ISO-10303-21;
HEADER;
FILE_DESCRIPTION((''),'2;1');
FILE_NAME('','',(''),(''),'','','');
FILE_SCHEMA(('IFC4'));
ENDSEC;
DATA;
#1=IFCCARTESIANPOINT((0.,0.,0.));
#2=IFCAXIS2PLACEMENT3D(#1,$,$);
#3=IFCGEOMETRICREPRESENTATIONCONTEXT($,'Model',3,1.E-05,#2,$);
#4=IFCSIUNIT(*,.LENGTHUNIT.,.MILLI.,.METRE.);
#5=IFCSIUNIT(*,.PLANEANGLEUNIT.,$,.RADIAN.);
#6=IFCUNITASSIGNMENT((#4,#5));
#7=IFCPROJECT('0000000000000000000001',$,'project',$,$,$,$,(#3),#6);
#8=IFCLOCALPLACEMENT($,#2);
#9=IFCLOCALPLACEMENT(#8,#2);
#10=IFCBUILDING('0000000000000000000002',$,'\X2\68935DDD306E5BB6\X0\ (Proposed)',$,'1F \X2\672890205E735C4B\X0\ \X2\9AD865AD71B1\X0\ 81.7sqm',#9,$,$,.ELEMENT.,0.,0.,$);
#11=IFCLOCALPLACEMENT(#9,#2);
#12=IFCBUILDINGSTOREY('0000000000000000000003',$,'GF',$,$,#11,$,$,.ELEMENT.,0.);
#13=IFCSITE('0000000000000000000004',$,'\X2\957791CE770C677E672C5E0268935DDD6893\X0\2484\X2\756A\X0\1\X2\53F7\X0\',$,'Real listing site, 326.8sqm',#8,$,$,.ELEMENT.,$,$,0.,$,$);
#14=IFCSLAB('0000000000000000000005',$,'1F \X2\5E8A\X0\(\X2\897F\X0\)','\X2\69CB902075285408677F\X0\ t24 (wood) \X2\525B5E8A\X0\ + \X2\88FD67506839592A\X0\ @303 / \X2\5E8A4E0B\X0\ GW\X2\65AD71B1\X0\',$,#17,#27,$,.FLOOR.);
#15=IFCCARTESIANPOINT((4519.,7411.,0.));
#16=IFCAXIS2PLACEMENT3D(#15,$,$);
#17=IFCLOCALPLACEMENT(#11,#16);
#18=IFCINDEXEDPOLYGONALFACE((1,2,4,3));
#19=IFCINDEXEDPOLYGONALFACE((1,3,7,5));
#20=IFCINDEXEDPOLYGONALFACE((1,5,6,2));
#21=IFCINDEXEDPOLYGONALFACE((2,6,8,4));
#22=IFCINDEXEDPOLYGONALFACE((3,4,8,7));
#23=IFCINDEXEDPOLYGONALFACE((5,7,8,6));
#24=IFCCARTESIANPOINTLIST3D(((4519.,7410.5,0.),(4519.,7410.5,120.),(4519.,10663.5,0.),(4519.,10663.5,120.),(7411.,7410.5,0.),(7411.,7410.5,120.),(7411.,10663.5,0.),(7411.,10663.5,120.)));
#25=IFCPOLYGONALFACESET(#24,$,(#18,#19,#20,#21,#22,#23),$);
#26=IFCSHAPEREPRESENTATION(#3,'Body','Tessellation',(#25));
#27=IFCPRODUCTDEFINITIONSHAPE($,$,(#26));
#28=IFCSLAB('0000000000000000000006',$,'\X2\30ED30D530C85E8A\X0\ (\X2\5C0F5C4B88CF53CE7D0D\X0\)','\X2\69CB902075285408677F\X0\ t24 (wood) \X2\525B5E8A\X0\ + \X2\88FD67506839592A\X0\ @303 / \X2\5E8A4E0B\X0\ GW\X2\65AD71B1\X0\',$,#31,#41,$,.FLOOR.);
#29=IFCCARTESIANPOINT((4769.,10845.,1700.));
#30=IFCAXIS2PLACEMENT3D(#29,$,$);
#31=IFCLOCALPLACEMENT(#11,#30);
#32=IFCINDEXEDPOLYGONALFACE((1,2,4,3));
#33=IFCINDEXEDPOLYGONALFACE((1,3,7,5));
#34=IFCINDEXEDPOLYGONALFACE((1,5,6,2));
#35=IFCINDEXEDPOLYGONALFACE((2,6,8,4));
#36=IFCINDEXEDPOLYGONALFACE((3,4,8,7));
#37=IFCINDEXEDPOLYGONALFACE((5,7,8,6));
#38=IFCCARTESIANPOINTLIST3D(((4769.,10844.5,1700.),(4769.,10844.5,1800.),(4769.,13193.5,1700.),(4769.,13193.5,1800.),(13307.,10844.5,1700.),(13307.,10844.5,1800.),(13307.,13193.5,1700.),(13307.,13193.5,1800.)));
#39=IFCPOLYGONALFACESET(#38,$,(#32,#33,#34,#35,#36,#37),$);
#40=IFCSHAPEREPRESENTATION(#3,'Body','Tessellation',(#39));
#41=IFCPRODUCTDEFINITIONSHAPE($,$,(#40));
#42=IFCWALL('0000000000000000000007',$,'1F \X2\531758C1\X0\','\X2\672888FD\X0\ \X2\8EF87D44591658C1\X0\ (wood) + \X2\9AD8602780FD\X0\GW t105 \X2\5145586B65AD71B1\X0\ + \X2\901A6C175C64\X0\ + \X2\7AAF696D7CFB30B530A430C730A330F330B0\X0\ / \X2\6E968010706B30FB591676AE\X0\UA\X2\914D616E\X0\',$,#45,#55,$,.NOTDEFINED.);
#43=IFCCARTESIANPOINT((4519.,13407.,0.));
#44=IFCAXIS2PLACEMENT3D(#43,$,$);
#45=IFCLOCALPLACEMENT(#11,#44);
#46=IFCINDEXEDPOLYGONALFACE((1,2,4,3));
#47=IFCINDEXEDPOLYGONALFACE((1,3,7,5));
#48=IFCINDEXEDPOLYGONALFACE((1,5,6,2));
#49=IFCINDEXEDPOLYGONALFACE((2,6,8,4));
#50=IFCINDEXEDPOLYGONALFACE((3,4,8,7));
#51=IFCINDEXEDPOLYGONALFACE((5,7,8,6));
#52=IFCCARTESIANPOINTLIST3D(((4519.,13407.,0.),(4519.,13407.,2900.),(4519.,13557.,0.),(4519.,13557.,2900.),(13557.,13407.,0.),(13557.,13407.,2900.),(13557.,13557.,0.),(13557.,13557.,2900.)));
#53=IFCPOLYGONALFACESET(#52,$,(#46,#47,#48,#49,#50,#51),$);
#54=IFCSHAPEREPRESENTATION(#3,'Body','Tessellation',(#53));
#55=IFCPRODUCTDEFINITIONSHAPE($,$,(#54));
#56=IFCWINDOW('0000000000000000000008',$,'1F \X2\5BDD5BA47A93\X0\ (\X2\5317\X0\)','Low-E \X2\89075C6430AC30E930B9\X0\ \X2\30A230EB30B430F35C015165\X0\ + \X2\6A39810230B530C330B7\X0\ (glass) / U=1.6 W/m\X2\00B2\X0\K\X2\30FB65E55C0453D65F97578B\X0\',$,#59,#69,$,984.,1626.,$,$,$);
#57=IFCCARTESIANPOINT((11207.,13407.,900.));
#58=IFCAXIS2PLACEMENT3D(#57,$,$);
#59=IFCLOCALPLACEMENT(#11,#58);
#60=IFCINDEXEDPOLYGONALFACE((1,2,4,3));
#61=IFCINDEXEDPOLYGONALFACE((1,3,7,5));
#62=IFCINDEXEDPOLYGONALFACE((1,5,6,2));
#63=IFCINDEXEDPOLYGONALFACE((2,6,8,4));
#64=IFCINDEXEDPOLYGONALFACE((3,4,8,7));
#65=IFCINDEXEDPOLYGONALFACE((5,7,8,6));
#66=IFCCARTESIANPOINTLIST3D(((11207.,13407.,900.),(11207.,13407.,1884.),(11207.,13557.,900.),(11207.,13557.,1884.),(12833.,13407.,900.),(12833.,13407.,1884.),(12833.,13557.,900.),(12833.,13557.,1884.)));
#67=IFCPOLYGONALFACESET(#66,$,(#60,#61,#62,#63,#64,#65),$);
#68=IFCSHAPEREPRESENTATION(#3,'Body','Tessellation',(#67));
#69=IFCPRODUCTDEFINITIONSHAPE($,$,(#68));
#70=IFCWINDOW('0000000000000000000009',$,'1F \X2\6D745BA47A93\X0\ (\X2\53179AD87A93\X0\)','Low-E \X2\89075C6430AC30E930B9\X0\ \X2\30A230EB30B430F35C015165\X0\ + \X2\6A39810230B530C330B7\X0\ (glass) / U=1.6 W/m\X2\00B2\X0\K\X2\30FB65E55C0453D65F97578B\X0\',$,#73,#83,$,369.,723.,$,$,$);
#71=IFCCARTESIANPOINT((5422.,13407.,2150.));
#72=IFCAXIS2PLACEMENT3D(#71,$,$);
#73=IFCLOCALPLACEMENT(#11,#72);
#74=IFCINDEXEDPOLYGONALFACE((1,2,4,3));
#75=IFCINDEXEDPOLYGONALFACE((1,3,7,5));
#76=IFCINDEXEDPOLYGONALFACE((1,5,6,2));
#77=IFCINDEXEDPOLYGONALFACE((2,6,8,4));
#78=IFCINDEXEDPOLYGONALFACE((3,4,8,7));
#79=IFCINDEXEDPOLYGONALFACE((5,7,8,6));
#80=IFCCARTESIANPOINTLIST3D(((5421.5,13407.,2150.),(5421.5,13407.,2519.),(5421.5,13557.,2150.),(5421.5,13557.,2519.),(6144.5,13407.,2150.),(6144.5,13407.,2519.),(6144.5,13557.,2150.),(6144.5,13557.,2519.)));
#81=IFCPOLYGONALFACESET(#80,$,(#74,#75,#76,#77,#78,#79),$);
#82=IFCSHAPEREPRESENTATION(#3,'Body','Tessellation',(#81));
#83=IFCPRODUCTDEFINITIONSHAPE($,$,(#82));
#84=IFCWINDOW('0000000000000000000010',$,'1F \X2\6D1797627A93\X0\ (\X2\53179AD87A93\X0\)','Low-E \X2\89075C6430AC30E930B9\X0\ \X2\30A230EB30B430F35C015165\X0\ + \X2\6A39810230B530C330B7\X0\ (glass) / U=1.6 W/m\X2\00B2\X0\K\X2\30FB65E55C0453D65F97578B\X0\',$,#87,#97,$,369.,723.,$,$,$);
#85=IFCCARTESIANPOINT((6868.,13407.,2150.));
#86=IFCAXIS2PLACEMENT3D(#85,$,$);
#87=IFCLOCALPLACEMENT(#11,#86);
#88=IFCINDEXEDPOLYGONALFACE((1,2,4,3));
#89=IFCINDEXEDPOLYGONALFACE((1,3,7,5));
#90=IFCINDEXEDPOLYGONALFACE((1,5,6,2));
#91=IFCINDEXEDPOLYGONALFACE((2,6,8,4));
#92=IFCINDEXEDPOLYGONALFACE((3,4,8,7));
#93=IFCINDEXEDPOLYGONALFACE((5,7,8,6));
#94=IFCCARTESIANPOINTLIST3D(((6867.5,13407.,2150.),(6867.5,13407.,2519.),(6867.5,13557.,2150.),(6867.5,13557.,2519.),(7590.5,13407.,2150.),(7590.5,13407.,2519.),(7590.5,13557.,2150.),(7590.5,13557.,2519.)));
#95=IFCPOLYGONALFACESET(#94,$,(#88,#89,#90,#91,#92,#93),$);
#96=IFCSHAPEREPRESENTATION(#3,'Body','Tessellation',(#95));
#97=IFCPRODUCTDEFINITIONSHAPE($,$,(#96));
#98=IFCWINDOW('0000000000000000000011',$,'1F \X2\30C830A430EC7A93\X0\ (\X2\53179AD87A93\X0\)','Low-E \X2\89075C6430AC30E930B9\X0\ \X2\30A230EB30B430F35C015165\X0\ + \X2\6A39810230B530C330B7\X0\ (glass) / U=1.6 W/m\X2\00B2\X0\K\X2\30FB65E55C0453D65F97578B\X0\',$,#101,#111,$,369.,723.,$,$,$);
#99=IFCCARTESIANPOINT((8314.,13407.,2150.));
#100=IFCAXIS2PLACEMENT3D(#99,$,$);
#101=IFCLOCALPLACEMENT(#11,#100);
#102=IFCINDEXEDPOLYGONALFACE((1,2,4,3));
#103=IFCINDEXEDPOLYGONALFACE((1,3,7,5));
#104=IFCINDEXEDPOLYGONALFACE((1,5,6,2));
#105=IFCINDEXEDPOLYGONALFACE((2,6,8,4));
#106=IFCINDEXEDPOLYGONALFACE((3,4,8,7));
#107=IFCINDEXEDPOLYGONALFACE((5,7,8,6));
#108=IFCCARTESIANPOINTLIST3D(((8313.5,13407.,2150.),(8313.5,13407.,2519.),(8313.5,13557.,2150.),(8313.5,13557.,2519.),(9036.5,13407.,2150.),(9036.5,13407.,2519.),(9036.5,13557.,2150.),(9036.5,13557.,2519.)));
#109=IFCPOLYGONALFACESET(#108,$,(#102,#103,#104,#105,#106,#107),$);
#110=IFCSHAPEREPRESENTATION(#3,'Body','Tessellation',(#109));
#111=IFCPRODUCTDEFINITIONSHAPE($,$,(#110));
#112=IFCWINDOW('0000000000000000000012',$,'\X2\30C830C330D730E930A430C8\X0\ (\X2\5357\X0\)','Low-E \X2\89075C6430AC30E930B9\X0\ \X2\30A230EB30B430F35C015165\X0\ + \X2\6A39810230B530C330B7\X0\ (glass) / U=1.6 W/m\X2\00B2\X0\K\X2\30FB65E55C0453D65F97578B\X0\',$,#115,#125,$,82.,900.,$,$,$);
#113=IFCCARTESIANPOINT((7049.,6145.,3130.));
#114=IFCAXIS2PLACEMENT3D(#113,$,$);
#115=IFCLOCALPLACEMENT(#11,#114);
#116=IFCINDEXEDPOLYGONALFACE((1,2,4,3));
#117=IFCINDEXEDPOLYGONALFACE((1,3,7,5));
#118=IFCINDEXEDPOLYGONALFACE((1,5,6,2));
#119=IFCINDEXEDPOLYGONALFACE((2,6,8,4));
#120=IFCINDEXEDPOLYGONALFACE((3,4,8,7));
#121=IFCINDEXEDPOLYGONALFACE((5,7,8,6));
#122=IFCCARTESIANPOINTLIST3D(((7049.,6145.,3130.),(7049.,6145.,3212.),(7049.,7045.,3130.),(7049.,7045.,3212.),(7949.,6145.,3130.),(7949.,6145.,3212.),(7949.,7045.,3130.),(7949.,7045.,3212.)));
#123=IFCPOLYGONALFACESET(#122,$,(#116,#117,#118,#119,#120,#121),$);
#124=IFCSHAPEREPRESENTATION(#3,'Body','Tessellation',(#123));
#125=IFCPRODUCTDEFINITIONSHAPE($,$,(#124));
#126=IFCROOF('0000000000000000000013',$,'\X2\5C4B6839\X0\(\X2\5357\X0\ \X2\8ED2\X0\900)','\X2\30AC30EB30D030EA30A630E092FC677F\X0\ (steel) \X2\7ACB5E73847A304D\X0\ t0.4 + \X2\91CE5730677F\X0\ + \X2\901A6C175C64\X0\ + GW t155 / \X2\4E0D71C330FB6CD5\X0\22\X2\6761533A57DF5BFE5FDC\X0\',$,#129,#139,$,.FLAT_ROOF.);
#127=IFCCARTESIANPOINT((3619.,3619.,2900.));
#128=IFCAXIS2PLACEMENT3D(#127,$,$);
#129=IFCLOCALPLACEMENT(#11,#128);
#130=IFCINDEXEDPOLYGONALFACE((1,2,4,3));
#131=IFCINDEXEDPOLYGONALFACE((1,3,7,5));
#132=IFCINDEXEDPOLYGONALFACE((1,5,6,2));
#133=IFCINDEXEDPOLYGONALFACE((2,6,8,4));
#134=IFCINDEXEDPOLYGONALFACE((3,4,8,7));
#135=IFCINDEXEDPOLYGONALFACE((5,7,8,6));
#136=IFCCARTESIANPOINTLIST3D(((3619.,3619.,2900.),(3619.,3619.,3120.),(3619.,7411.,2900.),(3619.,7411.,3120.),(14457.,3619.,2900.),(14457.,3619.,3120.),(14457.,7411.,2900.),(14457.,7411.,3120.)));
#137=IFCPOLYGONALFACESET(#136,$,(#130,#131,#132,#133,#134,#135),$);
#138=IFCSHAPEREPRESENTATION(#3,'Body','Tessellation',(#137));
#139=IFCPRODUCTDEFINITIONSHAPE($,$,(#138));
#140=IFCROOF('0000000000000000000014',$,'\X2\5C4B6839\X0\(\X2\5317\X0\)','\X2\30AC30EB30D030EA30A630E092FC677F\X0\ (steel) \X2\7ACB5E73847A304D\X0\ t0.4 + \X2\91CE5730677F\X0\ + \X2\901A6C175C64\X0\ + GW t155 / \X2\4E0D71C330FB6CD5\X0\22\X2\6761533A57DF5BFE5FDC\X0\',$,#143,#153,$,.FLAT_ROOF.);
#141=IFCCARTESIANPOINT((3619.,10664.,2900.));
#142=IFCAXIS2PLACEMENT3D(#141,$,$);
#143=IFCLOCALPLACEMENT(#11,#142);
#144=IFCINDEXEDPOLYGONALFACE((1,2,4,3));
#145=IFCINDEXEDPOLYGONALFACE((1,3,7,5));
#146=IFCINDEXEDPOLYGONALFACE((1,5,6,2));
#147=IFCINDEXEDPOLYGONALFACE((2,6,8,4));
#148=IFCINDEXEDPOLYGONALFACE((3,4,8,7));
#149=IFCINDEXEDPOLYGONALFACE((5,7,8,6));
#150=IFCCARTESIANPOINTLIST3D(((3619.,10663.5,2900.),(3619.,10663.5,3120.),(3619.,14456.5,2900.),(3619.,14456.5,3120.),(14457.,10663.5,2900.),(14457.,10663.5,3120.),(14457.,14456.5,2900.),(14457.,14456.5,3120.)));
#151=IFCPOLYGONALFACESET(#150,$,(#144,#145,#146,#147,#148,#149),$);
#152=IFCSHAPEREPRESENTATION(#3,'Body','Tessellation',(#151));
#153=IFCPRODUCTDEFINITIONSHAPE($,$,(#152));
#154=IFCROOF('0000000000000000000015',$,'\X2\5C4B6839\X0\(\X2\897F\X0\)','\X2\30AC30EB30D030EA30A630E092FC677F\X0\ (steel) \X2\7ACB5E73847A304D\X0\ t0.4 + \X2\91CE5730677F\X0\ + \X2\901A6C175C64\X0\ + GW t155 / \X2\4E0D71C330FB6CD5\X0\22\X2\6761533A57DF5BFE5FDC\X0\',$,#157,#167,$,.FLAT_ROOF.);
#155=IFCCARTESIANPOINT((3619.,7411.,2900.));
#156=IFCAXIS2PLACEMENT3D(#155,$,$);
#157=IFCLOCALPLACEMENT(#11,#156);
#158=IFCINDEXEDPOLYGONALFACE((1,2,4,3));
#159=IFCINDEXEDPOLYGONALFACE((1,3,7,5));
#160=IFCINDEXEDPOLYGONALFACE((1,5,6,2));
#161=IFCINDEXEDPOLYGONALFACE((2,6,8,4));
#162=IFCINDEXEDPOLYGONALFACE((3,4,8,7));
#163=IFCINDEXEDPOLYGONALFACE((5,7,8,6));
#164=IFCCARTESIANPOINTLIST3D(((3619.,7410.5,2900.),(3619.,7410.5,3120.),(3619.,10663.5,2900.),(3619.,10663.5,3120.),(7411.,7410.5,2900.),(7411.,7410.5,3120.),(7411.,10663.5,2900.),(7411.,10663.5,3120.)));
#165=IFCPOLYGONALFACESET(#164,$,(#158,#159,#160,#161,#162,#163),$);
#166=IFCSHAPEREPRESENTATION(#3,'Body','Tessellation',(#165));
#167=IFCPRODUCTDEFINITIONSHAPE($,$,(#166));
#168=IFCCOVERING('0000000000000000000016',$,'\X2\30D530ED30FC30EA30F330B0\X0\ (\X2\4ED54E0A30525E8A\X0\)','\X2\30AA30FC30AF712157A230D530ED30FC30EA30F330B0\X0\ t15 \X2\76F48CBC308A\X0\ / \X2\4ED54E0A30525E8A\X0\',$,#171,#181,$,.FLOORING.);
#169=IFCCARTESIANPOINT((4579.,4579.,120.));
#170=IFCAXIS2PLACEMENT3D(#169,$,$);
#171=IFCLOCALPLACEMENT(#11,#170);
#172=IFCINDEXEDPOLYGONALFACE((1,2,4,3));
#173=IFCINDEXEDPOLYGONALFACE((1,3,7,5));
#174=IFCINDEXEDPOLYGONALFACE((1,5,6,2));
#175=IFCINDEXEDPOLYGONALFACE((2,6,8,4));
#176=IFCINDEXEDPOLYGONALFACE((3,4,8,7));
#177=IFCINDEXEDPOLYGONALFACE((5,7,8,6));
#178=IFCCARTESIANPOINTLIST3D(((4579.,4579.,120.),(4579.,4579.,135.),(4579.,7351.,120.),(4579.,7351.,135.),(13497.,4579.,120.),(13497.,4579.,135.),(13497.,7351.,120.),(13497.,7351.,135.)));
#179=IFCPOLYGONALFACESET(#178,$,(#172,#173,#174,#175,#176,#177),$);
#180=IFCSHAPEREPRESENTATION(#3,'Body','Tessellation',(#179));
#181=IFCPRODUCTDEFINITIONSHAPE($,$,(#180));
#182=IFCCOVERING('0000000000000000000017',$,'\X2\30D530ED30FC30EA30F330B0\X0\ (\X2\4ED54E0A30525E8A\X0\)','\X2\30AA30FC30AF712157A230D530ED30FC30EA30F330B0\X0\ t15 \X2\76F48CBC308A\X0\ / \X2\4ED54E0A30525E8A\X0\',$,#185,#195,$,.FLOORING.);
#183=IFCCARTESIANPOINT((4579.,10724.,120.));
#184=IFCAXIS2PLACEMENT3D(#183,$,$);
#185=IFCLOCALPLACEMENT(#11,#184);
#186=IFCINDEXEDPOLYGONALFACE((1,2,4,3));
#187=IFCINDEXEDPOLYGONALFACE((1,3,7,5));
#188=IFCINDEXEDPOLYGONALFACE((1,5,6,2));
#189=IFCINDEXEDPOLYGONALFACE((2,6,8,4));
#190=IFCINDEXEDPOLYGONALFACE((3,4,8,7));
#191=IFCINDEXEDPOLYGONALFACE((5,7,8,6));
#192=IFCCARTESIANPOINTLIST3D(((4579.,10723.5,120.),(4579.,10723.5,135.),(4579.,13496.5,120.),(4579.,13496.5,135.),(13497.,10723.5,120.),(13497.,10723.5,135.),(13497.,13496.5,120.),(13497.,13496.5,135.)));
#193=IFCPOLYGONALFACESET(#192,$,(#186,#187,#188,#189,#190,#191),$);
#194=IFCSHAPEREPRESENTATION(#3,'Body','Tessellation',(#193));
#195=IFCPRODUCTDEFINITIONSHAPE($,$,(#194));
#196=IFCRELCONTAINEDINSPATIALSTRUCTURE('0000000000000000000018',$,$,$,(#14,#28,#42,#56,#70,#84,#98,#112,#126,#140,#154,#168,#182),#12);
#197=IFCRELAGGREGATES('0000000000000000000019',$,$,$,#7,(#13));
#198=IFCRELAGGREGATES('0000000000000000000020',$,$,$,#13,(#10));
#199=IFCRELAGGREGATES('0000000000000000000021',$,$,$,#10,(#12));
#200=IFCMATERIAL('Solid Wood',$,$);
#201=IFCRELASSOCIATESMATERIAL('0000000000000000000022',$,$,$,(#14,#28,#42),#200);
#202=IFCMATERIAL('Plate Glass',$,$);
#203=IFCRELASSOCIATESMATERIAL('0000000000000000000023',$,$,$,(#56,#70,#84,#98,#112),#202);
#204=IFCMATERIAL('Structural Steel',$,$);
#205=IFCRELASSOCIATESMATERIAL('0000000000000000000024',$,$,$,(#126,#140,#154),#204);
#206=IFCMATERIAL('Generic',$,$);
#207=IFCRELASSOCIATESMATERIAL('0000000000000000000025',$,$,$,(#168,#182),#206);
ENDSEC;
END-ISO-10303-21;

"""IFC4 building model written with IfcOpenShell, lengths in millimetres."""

from ifc_helpers import new_model, si_unit, frame, frame_2d, origin, place, context, project, spatial, rectangle, extrude, material, element, fill, save


model = new_model("IFC4")

# Units and contexts
model_context = context("Model", 3, precision=1e-05, world=origin())
ifc_project = project(units=[si_unit("LENGTHUNIT", "METRE", prefix="MILLI"), si_unit("PLANEANGLEUNIT", "RADIAN")], contexts=[model_context])

# Site, building, storey
site_placement = place(None, origin())
site = spatial("IfcSite", under=ifc_project, at=site_placement, Name="長野県松本市梓川梓2484番1号", ObjectType="Real listing site, 326.8sqm", CompositionType="ELEMENT", RefElevation=0.0)
building_placement = place(site_placement, origin())
building = spatial("IfcBuilding", under=site, at=building_placement, Name="梓川の家 (Proposed)", ObjectType="1F 木造平屋 高断熱 81.7sqm", CompositionType="ELEMENT", ElevationOfRefHeight=0.0, ElevationOfTerrain=0.0)
storey_placement = place(building_placement, origin())
storey = spatial("IfcBuildingStorey", under=building, at=storey_placement, Name="GF", CompositionType="ELEMENT", Elevation=0.0)

# Slabs
ifc_material_1 = material(Name="Solid Wood")
slab_1_placement = place(storey_placement, frame((4519.0, 7411.0, 0.0)))
element("IfcSlab", 1, at=slab_1_placement, inside=storey, material=ifc_material_1, Name="1F 床(西)", Description="構造用合板 t24 (wood) 剛床 + 製材根太 @303 / 床下 GW断熱", PredefinedType="FLOOR", context=model_context, shape_type="SweptSolid", body=[
    extrude(rectangle(XDim=2892.0, YDim=3253.0, at=frame_2d((1446.0, 1626.0))), frame((4519.0, 7411.0, 0.0)), (0.0, 0.0, 1.0), 120.0),
])
slab_2_placement = place(storey_placement, frame((4769.0, 10845.0, 1700.0)))
element("IfcSlab", 2, at=slab_2_placement, inside=storey, material=ifc_material_1, Name="ロフト床 (小屋裏収納)", Description="構造用合板 t24 (wood) 剛床 + 製材根太 @303 / 床下 GW断熱", PredefinedType="FLOOR", context=model_context, shape_type="SweptSolid", body=[
    extrude(rectangle(XDim=8538.0, YDim=2349.0, at=frame_2d((4269.0, 1174.0))), frame((4769.0, 10845.0, 1700.0)), (0.0, 0.0, 1.0), 100.0),
])

# Shared definitions
ifc_material_2 = material(Name="Plate Glass")

# Wall, openings, windows
wall_1_placement = place(storey_placement, frame((4519.0, 13407.0, 0.0)))
wall_1 = element("IfcWall", 3, at=wall_1_placement, inside=storey, material=ifc_material_1, Name="1F 北壁", Description="木製 軸組外壁 (wood) + 高性能GW t105 充填断熱 + 通気層 + 窯業系サイディング / 準耐火・外皮UA配慮", PredefinedType="NOTDEFINED", context=model_context, shape_type="SweptSolid", body=[
    extrude(rectangle(XDim=9038.0, YDim=150.0, at=frame_2d((4519.0, 75.0))), frame((4519.0, 13407.0, 0.0)), (0.0, 0.0, 1.0), 2900.0),
])
opening_1_placement = place(storey_placement, frame((11207.0, 13407.0, 900.0)))
opening_1 = element("IfcOpeningElement", 4, at=opening_1_placement, cuts=wall_1, PredefinedType="NOTDEFINED", context=model_context, shape_type="SweptSolid", body=[
    extrude(rectangle(XDim=1626.0, YDim=150.0, at=frame_2d((813.0, 75.0))), frame((11207.0, 13407.0, 900.0)), (0.0, 0.0, 1.0), 984.0),
])
opening_2_placement = place(storey_placement, frame((5422.0, 13407.0, 2150.0)))
opening_2 = element("IfcOpeningElement", 5, at=opening_2_placement, cuts=wall_1, PredefinedType="NOTDEFINED", context=model_context, shape_type="SweptSolid", body=[
    extrude(rectangle(XDim=723.0, YDim=150.0, at=frame_2d((361.0, 75.0))), frame((5422.0, 13407.0, 2150.0)), (0.0, 0.0, 1.0), 369.0),
])
opening_3_placement = place(storey_placement, frame((6868.0, 13407.0, 2150.0)))
opening_3 = element("IfcOpeningElement", 6, at=opening_3_placement, cuts=wall_1, PredefinedType="NOTDEFINED", context=model_context, shape_type="SweptSolid", body=[
    extrude(rectangle(XDim=723.0, YDim=150.0, at=frame_2d((361.0, 75.0))), frame((6868.0, 13407.0, 2150.0)), (0.0, 0.0, 1.0), 369.0),
])
opening_4_placement = place(storey_placement, frame((8314.0, 13407.0, 2150.0)))
opening_4 = element("IfcOpeningElement", 7, at=opening_4_placement, cuts=wall_1, PredefinedType="NOTDEFINED", context=model_context, shape_type="SweptSolid", body=[
    extrude(rectangle(XDim=723.0, YDim=150.0, at=frame_2d((361.0, 75.0))), frame((8314.0, 13407.0, 2150.0)), (0.0, 0.0, 1.0), 369.0),
])
window_1_placement = place(storey_placement, frame((11207.0, 13407.0, 900.0)))
window_1 = element("IfcWindow", 8, at=window_1_placement, inside=storey, material=ifc_material_2, Name="1F 寝室窓 (北)", Description="Low-E 複層ガラス アルゴン封入 + 樹脂サッシ (glass) / U=1.6 W/m²K・日射取得型", OverallHeight=984.0, OverallWidth=1626.0, context=model_context, shape_type="SweptSolid", body=[
    extrude(rectangle(XDim=1626.0, YDim=150.0, at=frame_2d((813.0, 75.0))), frame((11207.0, 13407.0, 900.0)), (0.0, 0.0, 1.0), 984.0),
])
fill(opening_1, window_1)
window_2_placement = place(storey_placement, frame((5422.0, 13407.0, 2150.0)))
window_2 = element("IfcWindow", 9, at=window_2_placement, inside=storey, material=ifc_material_2, Name="1F 浴室窓 (北高窓)", Description="Low-E 複層ガラス アルゴン封入 + 樹脂サッシ (glass) / U=1.6 W/m²K・日射取得型", OverallHeight=369.0, OverallWidth=723.0, context=model_context, shape_type="SweptSolid", body=[
    extrude(rectangle(XDim=723.0, YDim=150.0, at=frame_2d((361.0, 75.0))), frame((5422.0, 13407.0, 2150.0)), (0.0, 0.0, 1.0), 369.0),
])
fill(opening_2, window_2)
window_3_placement = place(storey_placement, frame((6868.0, 13407.0, 2150.0)))
window_3 = element("IfcWindow", 10, at=window_3_placement, inside=storey, material=ifc_material_2, Name="1F 洗面窓 (北高窓)", Description="Low-E 複層ガラス アルゴン封入 + 樹脂サッシ (glass) / U=1.6 W/m²K・日射取得型", OverallHeight=369.0, OverallWidth=723.0, context=model_context, shape_type="SweptSolid", body=[
    extrude(rectangle(XDim=723.0, YDim=150.0, at=frame_2d((361.0, 75.0))), frame((6868.0, 13407.0, 2150.0)), (0.0, 0.0, 1.0), 369.0),
])
fill(opening_3, window_3)
window_4_placement = place(storey_placement, frame((8314.0, 13407.0, 2150.0)))
window_4 = element("IfcWindow", 11, at=window_4_placement, inside=storey, material=ifc_material_2, Name="1F トイレ窓 (北高窓)", Description="Low-E 複層ガラス アルゴン封入 + 樹脂サッシ (glass) / U=1.6 W/m²K・日射取得型", OverallHeight=369.0, OverallWidth=723.0, context=model_context, shape_type="SweptSolid", body=[
    extrude(rectangle(XDim=723.0, YDim=150.0, at=frame_2d((361.0, 75.0))), frame((8314.0, 13407.0, 2150.0)), (0.0, 0.0, 1.0), 369.0),
])
fill(opening_4, window_4)

# Window
window_5_placement = place(storey_placement, frame((7049.0, 6145.0, 3130.0)))
element("IfcWindow", 12, at=window_5_placement, inside=storey, material=ifc_material_2, Name="トップライト (南)", Description="Low-E 複層ガラス アルゴン封入 + 樹脂サッシ (glass) / U=1.6 W/m²K・日射取得型", OverallHeight=82.0, OverallWidth=900.0, context=model_context, shape_type="SweptSolid", body=[
    extrude(rectangle(XDim=900.0, YDim=900.0, at=frame_2d((450.0, 450.0))), frame((7049.0, 6145.0, 3130.0)), (0.0, 0.0, 1.0), 82.0),
])

# Roofs
ifc_material_3 = material(Name="Structural Steel")
roof_1_placement = place(storey_placement, frame((3619.0, 3619.0, 2900.0)))
element("IfcRoof", 13, at=roof_1_placement, inside=storey, material=ifc_material_3, Name="屋根(南 軒900)", Description="ガルバリウム鋼板 (steel) 立平葺き t0.4 + 野地板 + 通気層 + GW t155 / 不燃・法22条区域対応", PredefinedType="FLAT_ROOF", context=model_context, shape_type="SweptSolid", body=[
    extrude(rectangle(XDim=10838.0, YDim=3792.0, at=frame_2d((5419.0, 1896.0))), frame((3619.0, 3619.0, 2900.0)), (0.0, 0.0, 1.0), 220.0),
])
roof_2_placement = place(storey_placement, frame((3619.0, 10664.0, 2900.0)))
element("IfcRoof", 14, at=roof_2_placement, inside=storey, material=ifc_material_3, Name="屋根(北)", Description="ガルバリウム鋼板 (steel) 立平葺き t0.4 + 野地板 + 通気層 + GW t155 / 不燃・法22条区域対応", PredefinedType="FLAT_ROOF", context=model_context, shape_type="SweptSolid", body=[
    extrude(rectangle(XDim=10838.0, YDim=3793.0, at=frame_2d((5419.0, 1896.0))), frame((3619.0, 10664.0, 2900.0)), (0.0, 0.0, 1.0), 220.0),
])
roof_3_placement = place(storey_placement, frame((3619.0, 7411.0, 2900.0)))
element("IfcRoof", 15, at=roof_3_placement, inside=storey, material=ifc_material_3, Name="屋根(西)", Description="ガルバリウム鋼板 (steel) 立平葺き t0.4 + 野地板 + 通気層 + GW t155 / 不燃・法22条区域対応", PredefinedType="FLAT_ROOF", context=model_context, shape_type="SweptSolid", body=[
    extrude(rectangle(XDim=3792.0, YDim=3253.0, at=frame_2d((1896.0, 1626.0))), frame((3619.0, 7411.0, 2900.0)), (0.0, 0.0, 1.0), 220.0),
])

# Coverings
ifc_material_4 = material(Name="Generic")
covering_1_placement = place(storey_placement, frame((4579.0, 4579.0, 120.0)))
element("IfcCovering", 16, at=covering_1_placement, inside=storey, material=ifc_material_4, Name="フローリング (仕上げ床)", Description="オーク無垢フローリング t15 直貼り / 仕上げ床", PredefinedType="FLOORING", context=model_context, shape_type="SweptSolid", body=[
    extrude(rectangle(XDim=8918.0, YDim=2772.0, at=frame_2d((4459.0, 1386.0))), frame((4579.0, 4579.0, 120.0)), (0.0, 0.0, 1.0), 15.0),
])
covering_2_placement = place(storey_placement, frame((4579.0, 10724.0, 120.0)))
element("IfcCovering", 17, at=covering_2_placement, inside=storey, material=ifc_material_4, Name="フローリング (仕上げ床)", Description="オーク無垢フローリング t15 直貼り / 仕上げ床", PredefinedType="FLOORING", context=model_context, shape_type="SweptSolid", body=[
    extrude(rectangle(XDim=8918.0, YDim=2773.0, at=frame_2d((4459.0, 1386.0))), frame((4579.0, 10724.0, 120.0)), (0.0, 0.0, 1.0), 15.0),
])

save(model, "model.ifc")
